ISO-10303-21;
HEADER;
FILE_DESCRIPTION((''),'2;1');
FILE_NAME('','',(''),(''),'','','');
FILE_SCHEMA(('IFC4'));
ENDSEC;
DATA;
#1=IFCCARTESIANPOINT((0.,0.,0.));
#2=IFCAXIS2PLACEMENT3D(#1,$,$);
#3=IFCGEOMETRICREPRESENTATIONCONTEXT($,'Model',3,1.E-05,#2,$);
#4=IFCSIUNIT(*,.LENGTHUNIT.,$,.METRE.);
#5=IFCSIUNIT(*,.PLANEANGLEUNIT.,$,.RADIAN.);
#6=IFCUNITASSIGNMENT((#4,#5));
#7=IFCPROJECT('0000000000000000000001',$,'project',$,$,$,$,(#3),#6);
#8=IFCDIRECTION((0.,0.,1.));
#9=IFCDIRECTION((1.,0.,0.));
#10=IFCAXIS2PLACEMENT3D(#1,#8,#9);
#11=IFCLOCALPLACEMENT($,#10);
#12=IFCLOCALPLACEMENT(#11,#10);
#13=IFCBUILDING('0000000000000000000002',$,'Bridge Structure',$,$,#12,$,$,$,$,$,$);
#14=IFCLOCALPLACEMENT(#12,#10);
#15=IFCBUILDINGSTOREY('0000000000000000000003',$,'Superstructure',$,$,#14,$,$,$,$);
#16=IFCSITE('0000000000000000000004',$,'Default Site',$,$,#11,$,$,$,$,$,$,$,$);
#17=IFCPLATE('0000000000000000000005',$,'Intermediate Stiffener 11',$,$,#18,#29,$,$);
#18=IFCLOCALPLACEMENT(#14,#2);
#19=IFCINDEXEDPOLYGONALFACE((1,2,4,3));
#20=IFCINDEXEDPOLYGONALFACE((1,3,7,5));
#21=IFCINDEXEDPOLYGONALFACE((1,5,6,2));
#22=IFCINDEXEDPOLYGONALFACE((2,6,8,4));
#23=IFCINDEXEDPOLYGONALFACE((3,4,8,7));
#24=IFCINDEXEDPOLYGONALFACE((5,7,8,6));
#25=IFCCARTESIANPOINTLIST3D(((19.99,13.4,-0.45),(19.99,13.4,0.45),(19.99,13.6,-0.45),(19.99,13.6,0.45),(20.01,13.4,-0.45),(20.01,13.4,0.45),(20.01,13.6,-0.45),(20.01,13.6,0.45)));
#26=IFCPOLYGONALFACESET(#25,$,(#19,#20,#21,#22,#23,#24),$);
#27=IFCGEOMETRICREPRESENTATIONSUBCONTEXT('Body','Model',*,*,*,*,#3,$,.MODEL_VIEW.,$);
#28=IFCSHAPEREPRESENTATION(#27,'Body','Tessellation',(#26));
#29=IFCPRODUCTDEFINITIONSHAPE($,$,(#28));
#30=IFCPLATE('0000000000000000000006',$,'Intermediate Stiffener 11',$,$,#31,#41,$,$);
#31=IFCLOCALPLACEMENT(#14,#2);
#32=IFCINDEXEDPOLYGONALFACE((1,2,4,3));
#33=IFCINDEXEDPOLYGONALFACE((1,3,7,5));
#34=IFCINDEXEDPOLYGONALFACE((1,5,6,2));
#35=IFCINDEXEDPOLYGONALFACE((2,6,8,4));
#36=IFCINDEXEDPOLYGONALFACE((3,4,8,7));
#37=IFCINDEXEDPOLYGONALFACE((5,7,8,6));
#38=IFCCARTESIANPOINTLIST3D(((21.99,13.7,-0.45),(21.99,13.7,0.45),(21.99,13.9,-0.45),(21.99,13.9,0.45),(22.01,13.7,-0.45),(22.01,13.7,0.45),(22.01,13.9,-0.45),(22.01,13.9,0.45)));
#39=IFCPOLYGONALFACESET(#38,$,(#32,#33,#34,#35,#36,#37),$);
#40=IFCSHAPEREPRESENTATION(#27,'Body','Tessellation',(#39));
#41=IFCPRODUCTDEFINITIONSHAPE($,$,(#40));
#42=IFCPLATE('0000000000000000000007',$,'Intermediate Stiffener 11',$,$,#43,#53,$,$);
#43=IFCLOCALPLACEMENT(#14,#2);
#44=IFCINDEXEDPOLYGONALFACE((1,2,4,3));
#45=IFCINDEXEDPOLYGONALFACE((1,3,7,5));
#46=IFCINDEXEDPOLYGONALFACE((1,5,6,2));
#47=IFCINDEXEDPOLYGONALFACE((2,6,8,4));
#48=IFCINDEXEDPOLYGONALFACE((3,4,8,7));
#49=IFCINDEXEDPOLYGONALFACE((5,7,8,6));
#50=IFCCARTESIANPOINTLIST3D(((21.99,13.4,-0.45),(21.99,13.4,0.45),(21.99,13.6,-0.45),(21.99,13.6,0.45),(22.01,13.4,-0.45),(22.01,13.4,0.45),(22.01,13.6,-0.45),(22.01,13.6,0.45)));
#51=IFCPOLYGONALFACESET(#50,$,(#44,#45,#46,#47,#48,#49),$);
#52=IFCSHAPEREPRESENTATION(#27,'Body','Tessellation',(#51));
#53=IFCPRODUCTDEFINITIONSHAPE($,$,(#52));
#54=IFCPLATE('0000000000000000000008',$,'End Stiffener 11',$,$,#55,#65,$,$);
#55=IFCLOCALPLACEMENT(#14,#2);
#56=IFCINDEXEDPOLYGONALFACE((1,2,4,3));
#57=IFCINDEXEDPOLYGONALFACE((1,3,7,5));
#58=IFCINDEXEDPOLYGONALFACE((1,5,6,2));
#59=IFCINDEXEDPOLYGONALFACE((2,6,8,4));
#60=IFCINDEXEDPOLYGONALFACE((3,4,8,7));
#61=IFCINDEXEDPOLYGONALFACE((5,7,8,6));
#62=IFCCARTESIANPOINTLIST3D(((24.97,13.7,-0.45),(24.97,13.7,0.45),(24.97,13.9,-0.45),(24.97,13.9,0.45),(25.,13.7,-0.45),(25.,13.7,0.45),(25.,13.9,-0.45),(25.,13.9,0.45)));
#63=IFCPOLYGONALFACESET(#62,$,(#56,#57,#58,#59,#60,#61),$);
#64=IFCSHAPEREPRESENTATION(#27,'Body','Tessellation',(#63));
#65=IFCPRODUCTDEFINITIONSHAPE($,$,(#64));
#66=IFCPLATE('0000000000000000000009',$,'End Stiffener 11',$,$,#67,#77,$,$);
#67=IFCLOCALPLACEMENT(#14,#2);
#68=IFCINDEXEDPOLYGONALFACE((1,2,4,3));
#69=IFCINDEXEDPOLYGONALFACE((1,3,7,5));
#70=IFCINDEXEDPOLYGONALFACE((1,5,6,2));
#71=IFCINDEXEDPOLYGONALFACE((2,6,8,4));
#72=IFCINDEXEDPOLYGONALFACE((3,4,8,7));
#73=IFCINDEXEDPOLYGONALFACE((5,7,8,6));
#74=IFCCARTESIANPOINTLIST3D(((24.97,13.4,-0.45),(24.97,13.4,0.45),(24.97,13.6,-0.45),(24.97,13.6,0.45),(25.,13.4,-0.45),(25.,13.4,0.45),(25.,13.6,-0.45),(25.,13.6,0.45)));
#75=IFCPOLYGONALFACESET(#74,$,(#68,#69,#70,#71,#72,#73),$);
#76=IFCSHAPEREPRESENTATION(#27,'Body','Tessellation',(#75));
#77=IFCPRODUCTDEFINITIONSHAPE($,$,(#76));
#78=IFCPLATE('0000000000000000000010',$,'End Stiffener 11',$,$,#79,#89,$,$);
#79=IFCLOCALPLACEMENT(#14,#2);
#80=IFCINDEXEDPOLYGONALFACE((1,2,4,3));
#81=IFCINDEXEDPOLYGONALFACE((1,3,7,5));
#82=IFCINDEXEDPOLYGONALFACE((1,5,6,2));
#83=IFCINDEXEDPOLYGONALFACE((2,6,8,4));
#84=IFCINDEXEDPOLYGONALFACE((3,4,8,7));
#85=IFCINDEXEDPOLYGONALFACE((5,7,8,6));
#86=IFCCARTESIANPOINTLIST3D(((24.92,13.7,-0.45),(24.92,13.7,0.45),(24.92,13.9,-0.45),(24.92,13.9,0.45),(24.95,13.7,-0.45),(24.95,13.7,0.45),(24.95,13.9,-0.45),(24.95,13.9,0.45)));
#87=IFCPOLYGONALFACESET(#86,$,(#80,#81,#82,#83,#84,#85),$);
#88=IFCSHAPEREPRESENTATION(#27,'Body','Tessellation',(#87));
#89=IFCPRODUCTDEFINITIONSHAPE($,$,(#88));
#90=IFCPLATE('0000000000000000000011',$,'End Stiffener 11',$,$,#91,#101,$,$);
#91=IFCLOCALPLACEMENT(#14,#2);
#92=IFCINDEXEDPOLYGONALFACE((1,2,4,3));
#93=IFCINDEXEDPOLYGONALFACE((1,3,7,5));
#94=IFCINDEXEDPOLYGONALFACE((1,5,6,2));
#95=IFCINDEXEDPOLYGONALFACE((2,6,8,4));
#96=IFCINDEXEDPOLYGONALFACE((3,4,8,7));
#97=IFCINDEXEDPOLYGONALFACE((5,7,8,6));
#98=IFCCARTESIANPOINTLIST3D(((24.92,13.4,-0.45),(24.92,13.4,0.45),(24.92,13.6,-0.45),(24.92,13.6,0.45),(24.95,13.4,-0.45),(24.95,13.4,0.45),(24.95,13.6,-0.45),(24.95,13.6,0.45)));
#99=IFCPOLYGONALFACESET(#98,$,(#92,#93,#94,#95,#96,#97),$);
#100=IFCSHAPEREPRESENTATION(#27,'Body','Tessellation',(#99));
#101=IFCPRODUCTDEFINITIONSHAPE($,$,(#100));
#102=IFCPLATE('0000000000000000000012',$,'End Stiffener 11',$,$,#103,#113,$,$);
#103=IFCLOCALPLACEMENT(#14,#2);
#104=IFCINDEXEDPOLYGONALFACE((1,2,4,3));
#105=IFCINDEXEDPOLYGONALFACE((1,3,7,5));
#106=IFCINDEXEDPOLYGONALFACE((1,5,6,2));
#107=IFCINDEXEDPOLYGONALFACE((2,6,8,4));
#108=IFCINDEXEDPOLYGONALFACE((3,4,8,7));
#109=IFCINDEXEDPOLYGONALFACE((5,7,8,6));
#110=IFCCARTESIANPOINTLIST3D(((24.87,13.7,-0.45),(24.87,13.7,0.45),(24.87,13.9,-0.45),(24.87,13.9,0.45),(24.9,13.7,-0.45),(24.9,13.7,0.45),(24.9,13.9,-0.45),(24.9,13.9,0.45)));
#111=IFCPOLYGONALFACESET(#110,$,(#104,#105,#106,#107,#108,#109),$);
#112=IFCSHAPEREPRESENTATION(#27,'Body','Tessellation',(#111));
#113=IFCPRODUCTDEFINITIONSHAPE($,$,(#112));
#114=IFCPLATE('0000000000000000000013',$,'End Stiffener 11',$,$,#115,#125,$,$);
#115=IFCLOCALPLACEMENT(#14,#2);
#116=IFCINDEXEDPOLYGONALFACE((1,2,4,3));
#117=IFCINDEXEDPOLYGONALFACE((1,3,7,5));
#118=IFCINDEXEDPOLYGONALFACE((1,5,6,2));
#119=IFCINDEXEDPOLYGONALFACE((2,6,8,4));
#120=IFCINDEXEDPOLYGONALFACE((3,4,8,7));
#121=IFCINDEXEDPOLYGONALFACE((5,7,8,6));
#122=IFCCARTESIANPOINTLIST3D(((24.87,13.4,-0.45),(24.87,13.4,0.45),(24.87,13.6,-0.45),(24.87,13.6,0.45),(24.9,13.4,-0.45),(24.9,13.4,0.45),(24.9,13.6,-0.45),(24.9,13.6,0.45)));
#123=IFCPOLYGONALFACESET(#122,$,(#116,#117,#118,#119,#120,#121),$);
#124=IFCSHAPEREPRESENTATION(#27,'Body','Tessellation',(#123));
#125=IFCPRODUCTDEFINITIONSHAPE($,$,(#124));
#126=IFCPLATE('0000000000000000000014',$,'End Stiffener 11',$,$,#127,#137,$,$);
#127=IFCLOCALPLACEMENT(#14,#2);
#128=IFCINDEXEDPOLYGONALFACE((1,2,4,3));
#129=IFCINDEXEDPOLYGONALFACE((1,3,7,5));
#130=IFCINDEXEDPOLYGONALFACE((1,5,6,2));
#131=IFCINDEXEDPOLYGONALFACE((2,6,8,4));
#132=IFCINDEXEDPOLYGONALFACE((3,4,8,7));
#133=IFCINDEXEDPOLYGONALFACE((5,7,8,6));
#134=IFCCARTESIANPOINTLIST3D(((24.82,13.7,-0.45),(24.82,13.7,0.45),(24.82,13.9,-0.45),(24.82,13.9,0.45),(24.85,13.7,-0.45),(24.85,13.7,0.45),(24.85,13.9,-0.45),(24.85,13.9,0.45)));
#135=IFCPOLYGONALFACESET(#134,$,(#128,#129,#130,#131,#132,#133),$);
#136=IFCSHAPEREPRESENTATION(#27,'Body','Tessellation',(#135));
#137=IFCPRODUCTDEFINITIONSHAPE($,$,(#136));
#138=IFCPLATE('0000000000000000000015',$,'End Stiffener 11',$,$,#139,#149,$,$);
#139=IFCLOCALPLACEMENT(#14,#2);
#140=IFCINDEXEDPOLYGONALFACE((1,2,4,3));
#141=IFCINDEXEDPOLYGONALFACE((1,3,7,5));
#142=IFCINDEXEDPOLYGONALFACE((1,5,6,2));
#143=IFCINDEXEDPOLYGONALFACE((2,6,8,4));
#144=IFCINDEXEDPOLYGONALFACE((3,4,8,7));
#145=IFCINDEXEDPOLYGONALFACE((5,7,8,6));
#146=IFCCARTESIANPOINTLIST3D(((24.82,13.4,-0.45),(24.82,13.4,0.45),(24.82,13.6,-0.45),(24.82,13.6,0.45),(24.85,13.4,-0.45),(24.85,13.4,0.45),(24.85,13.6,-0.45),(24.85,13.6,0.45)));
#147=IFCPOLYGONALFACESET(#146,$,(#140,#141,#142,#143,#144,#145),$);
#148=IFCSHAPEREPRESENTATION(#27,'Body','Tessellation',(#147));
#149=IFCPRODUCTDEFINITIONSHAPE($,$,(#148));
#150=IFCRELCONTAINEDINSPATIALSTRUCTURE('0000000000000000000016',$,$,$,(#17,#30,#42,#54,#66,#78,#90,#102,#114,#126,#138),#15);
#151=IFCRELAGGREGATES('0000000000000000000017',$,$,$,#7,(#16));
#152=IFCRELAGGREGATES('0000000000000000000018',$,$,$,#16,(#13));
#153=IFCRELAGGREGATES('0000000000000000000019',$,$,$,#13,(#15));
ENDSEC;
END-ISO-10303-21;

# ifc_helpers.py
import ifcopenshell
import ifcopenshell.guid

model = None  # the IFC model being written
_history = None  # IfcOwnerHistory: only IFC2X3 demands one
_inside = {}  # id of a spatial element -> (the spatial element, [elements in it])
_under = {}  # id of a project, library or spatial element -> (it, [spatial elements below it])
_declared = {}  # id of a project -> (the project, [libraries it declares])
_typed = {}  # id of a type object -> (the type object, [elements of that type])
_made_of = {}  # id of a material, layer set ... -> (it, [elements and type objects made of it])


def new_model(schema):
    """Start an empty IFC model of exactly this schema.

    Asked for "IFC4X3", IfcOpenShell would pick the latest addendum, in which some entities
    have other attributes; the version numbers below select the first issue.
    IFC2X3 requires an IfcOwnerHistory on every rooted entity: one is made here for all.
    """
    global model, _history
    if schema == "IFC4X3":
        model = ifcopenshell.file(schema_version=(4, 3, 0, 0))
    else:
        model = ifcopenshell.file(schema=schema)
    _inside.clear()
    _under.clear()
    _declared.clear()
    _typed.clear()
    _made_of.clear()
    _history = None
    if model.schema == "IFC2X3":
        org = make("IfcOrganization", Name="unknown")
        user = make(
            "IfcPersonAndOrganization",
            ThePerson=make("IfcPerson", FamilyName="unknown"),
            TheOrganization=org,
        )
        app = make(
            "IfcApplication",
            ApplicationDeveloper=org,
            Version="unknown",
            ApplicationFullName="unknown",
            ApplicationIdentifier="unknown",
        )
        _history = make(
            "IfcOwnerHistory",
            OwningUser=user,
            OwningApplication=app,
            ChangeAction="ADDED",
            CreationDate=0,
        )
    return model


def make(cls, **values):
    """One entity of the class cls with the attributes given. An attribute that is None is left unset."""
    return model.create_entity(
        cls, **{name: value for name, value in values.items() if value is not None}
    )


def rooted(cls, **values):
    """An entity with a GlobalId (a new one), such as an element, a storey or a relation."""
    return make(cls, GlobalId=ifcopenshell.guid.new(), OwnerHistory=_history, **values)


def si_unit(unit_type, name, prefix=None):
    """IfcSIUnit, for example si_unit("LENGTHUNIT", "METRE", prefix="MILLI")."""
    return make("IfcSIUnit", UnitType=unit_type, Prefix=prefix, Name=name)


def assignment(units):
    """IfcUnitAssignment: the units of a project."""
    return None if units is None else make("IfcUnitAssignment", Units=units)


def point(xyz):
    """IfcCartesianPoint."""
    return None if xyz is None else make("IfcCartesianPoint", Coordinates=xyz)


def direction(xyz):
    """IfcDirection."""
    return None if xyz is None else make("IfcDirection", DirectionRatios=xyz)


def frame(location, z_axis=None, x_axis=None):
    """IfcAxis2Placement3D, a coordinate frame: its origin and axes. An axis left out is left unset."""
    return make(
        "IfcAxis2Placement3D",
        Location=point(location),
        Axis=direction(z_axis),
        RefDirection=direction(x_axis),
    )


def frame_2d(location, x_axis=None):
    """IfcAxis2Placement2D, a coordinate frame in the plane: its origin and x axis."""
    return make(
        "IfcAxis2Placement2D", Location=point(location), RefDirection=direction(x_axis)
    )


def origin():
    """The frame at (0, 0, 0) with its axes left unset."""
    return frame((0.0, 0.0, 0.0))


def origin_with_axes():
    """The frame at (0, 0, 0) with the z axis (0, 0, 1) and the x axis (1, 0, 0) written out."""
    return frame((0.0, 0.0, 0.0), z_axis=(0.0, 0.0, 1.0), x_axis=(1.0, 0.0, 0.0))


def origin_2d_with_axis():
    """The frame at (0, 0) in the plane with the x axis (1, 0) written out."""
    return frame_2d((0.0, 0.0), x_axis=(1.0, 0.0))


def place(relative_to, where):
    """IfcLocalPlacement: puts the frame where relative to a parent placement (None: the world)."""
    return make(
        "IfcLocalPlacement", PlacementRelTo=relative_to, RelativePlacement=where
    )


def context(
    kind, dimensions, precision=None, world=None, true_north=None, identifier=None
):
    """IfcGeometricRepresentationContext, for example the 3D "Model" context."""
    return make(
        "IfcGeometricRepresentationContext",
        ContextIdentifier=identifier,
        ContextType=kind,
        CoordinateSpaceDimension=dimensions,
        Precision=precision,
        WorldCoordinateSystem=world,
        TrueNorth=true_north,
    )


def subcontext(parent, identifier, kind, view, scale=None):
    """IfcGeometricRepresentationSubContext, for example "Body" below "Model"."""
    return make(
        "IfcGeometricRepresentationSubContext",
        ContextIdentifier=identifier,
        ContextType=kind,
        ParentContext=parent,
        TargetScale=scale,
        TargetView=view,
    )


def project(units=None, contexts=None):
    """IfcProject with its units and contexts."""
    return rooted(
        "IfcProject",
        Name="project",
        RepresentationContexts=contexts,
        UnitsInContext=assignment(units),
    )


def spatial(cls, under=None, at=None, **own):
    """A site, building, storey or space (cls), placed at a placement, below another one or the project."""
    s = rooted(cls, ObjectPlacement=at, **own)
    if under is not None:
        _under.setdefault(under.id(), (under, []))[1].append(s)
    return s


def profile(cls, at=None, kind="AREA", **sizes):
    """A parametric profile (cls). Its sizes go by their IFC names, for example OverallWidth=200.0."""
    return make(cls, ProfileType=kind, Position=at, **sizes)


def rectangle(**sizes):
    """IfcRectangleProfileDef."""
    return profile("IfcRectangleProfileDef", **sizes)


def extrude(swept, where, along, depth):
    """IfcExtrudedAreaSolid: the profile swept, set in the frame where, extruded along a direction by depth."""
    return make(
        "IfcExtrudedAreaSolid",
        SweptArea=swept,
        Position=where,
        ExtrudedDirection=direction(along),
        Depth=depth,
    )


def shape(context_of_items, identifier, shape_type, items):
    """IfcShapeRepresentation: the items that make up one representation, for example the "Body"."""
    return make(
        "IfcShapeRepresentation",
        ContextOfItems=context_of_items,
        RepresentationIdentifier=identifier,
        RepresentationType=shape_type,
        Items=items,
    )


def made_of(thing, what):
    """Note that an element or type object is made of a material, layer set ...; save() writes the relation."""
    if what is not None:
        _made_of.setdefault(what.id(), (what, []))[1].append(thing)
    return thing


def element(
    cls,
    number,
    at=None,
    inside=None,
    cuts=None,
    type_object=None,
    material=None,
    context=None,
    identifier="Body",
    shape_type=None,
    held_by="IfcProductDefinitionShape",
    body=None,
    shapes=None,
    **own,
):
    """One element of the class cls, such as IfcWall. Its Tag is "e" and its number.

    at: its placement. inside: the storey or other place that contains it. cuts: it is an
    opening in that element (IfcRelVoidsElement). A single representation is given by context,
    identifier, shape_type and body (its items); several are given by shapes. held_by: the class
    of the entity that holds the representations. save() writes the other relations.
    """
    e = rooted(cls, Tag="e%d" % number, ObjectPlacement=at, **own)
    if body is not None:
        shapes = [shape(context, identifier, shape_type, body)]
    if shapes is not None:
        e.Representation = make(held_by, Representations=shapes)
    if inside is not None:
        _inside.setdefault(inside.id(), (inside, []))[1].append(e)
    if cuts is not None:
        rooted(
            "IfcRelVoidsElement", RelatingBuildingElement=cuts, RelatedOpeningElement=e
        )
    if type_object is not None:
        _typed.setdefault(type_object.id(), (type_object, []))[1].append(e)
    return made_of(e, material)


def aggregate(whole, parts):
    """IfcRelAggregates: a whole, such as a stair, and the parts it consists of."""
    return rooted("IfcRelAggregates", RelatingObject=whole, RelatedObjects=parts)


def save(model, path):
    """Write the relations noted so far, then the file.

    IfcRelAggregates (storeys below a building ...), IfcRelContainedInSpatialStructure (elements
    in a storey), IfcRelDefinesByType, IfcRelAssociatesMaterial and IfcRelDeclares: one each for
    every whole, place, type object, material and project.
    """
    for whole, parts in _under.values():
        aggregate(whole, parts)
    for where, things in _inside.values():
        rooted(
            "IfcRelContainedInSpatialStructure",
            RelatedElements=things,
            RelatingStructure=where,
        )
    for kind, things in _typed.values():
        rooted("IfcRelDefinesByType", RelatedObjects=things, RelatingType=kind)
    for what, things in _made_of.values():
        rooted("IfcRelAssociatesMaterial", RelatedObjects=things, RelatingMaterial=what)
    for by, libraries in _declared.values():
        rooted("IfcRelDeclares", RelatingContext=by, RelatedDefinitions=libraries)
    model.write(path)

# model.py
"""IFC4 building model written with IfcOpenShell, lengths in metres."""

from ifc_helpers import new_model, si_unit, frame, origin, origin_with_axes, origin_2d_with_axis, place, context, subcontext, project, spatial, rectangle, extrude, element, save


model = new_model("IFC4")

# Units and contexts
model_context = context("Model", 3, precision=1e-05, world=origin())
body_context = subcontext(model_context, "Body", "Model", "MODEL_VIEW")
ifc_project = project(units=[si_unit("LENGTHUNIT", "METRE"), si_unit("PLANEANGLEUNIT", "RADIAN")], contexts=[model_context])

# Site, building, storey
site_placement = place(None, origin_with_axes())
site = spatial("IfcSite", under=ifc_project, at=site_placement, Name="Default Site")
building_placement = place(site_placement, origin_with_axes())
building = spatial("IfcBuilding", under=site, at=building_placement, Name="Bridge Structure")
storey_placement = place(building_placement, origin_with_axes())
storey = spatial("IfcBuildingStorey", under=building, at=storey_placement, Name="Superstructure")

# Plates
for number, where, z_axis, x_axis, name in (
    (1, (20.0, 13.5, -0.45), (0.0, 0.0, 1.0), (1.0, 0.0, 0.0), "Intermediate Stiffener 11"),
    (2, (22.0, 13.8, -0.45), (0.0, 0.0, 1.0), (1.0, 0.0, 0.0), "Intermediate Stiffener 11"),
    (3, (22.0, 13.5, -0.45), (0.0, 0.0, 1.0), (1.0, 0.0, 0.0), "Intermediate Stiffener 11"),
):
    element("IfcPlate", number, at=place(storey_placement, frame(where, z_axis=z_axis, x_axis=x_axis)), inside=storey, Name=name, context=body_context, shape_type="SweptSolid", body=[
        extrude(rectangle(XDim=0.02, YDim=0.2, at=origin_2d_with_axis()), origin_with_axes(), (0.0, 0.0, 1.0), 0.9),
    ])
for number, where, z_axis, x_axis, name in (
    (4, (24.985, 13.8, -0.45), (0.0, 0.0, 1.0), (1.0, 0.0, 0.0), "End Stiffener 11"),
    (5, (24.985, 13.5, -0.45), (0.0, 0.0, 1.0), (1.0, 0.0, 0.0), "End Stiffener 11"),
    (6, (24.935, 13.8, -0.45), (0.0, 0.0, 1.0), (1.0, 0.0, 0.0), "End Stiffener 11"),
    (7, (24.935, 13.5, -0.45), (0.0, 0.0, 1.0), (1.0, 0.0, 0.0), "End Stiffener 11"),
    (8, (24.885, 13.8, -0.45), (0.0, 0.0, 1.0), (1.0, 0.0, 0.0), "End Stiffener 11"),
    (9, (24.885, 13.5, -0.45), (0.0, 0.0, 1.0), (1.0, 0.0, 0.0), "End Stiffener 11"),
    (10, (24.835, 13.8, -0.45), (0.0, 0.0, 1.0), (1.0, 0.0, 0.0), "End Stiffener 11"),
    (11, (24.835, 13.5, -0.45), (0.0, 0.0, 1.0), (1.0, 0.0, 0.0), "End Stiffener 11"),
):
    element("IfcPlate", number, at=place(storey_placement, frame(where, z_axis=z_axis, x_axis=x_axis)), inside=storey, Name=name, context=body_context, shape_type="SweptSolid", body=[
        extrude(rectangle(XDim=0.03, YDim=0.2, at=origin_2d_with_axis()), origin_with_axes(), (0.0, 0.0, 1.0), 0.9),
    ])

save(model, "model.ifc")
